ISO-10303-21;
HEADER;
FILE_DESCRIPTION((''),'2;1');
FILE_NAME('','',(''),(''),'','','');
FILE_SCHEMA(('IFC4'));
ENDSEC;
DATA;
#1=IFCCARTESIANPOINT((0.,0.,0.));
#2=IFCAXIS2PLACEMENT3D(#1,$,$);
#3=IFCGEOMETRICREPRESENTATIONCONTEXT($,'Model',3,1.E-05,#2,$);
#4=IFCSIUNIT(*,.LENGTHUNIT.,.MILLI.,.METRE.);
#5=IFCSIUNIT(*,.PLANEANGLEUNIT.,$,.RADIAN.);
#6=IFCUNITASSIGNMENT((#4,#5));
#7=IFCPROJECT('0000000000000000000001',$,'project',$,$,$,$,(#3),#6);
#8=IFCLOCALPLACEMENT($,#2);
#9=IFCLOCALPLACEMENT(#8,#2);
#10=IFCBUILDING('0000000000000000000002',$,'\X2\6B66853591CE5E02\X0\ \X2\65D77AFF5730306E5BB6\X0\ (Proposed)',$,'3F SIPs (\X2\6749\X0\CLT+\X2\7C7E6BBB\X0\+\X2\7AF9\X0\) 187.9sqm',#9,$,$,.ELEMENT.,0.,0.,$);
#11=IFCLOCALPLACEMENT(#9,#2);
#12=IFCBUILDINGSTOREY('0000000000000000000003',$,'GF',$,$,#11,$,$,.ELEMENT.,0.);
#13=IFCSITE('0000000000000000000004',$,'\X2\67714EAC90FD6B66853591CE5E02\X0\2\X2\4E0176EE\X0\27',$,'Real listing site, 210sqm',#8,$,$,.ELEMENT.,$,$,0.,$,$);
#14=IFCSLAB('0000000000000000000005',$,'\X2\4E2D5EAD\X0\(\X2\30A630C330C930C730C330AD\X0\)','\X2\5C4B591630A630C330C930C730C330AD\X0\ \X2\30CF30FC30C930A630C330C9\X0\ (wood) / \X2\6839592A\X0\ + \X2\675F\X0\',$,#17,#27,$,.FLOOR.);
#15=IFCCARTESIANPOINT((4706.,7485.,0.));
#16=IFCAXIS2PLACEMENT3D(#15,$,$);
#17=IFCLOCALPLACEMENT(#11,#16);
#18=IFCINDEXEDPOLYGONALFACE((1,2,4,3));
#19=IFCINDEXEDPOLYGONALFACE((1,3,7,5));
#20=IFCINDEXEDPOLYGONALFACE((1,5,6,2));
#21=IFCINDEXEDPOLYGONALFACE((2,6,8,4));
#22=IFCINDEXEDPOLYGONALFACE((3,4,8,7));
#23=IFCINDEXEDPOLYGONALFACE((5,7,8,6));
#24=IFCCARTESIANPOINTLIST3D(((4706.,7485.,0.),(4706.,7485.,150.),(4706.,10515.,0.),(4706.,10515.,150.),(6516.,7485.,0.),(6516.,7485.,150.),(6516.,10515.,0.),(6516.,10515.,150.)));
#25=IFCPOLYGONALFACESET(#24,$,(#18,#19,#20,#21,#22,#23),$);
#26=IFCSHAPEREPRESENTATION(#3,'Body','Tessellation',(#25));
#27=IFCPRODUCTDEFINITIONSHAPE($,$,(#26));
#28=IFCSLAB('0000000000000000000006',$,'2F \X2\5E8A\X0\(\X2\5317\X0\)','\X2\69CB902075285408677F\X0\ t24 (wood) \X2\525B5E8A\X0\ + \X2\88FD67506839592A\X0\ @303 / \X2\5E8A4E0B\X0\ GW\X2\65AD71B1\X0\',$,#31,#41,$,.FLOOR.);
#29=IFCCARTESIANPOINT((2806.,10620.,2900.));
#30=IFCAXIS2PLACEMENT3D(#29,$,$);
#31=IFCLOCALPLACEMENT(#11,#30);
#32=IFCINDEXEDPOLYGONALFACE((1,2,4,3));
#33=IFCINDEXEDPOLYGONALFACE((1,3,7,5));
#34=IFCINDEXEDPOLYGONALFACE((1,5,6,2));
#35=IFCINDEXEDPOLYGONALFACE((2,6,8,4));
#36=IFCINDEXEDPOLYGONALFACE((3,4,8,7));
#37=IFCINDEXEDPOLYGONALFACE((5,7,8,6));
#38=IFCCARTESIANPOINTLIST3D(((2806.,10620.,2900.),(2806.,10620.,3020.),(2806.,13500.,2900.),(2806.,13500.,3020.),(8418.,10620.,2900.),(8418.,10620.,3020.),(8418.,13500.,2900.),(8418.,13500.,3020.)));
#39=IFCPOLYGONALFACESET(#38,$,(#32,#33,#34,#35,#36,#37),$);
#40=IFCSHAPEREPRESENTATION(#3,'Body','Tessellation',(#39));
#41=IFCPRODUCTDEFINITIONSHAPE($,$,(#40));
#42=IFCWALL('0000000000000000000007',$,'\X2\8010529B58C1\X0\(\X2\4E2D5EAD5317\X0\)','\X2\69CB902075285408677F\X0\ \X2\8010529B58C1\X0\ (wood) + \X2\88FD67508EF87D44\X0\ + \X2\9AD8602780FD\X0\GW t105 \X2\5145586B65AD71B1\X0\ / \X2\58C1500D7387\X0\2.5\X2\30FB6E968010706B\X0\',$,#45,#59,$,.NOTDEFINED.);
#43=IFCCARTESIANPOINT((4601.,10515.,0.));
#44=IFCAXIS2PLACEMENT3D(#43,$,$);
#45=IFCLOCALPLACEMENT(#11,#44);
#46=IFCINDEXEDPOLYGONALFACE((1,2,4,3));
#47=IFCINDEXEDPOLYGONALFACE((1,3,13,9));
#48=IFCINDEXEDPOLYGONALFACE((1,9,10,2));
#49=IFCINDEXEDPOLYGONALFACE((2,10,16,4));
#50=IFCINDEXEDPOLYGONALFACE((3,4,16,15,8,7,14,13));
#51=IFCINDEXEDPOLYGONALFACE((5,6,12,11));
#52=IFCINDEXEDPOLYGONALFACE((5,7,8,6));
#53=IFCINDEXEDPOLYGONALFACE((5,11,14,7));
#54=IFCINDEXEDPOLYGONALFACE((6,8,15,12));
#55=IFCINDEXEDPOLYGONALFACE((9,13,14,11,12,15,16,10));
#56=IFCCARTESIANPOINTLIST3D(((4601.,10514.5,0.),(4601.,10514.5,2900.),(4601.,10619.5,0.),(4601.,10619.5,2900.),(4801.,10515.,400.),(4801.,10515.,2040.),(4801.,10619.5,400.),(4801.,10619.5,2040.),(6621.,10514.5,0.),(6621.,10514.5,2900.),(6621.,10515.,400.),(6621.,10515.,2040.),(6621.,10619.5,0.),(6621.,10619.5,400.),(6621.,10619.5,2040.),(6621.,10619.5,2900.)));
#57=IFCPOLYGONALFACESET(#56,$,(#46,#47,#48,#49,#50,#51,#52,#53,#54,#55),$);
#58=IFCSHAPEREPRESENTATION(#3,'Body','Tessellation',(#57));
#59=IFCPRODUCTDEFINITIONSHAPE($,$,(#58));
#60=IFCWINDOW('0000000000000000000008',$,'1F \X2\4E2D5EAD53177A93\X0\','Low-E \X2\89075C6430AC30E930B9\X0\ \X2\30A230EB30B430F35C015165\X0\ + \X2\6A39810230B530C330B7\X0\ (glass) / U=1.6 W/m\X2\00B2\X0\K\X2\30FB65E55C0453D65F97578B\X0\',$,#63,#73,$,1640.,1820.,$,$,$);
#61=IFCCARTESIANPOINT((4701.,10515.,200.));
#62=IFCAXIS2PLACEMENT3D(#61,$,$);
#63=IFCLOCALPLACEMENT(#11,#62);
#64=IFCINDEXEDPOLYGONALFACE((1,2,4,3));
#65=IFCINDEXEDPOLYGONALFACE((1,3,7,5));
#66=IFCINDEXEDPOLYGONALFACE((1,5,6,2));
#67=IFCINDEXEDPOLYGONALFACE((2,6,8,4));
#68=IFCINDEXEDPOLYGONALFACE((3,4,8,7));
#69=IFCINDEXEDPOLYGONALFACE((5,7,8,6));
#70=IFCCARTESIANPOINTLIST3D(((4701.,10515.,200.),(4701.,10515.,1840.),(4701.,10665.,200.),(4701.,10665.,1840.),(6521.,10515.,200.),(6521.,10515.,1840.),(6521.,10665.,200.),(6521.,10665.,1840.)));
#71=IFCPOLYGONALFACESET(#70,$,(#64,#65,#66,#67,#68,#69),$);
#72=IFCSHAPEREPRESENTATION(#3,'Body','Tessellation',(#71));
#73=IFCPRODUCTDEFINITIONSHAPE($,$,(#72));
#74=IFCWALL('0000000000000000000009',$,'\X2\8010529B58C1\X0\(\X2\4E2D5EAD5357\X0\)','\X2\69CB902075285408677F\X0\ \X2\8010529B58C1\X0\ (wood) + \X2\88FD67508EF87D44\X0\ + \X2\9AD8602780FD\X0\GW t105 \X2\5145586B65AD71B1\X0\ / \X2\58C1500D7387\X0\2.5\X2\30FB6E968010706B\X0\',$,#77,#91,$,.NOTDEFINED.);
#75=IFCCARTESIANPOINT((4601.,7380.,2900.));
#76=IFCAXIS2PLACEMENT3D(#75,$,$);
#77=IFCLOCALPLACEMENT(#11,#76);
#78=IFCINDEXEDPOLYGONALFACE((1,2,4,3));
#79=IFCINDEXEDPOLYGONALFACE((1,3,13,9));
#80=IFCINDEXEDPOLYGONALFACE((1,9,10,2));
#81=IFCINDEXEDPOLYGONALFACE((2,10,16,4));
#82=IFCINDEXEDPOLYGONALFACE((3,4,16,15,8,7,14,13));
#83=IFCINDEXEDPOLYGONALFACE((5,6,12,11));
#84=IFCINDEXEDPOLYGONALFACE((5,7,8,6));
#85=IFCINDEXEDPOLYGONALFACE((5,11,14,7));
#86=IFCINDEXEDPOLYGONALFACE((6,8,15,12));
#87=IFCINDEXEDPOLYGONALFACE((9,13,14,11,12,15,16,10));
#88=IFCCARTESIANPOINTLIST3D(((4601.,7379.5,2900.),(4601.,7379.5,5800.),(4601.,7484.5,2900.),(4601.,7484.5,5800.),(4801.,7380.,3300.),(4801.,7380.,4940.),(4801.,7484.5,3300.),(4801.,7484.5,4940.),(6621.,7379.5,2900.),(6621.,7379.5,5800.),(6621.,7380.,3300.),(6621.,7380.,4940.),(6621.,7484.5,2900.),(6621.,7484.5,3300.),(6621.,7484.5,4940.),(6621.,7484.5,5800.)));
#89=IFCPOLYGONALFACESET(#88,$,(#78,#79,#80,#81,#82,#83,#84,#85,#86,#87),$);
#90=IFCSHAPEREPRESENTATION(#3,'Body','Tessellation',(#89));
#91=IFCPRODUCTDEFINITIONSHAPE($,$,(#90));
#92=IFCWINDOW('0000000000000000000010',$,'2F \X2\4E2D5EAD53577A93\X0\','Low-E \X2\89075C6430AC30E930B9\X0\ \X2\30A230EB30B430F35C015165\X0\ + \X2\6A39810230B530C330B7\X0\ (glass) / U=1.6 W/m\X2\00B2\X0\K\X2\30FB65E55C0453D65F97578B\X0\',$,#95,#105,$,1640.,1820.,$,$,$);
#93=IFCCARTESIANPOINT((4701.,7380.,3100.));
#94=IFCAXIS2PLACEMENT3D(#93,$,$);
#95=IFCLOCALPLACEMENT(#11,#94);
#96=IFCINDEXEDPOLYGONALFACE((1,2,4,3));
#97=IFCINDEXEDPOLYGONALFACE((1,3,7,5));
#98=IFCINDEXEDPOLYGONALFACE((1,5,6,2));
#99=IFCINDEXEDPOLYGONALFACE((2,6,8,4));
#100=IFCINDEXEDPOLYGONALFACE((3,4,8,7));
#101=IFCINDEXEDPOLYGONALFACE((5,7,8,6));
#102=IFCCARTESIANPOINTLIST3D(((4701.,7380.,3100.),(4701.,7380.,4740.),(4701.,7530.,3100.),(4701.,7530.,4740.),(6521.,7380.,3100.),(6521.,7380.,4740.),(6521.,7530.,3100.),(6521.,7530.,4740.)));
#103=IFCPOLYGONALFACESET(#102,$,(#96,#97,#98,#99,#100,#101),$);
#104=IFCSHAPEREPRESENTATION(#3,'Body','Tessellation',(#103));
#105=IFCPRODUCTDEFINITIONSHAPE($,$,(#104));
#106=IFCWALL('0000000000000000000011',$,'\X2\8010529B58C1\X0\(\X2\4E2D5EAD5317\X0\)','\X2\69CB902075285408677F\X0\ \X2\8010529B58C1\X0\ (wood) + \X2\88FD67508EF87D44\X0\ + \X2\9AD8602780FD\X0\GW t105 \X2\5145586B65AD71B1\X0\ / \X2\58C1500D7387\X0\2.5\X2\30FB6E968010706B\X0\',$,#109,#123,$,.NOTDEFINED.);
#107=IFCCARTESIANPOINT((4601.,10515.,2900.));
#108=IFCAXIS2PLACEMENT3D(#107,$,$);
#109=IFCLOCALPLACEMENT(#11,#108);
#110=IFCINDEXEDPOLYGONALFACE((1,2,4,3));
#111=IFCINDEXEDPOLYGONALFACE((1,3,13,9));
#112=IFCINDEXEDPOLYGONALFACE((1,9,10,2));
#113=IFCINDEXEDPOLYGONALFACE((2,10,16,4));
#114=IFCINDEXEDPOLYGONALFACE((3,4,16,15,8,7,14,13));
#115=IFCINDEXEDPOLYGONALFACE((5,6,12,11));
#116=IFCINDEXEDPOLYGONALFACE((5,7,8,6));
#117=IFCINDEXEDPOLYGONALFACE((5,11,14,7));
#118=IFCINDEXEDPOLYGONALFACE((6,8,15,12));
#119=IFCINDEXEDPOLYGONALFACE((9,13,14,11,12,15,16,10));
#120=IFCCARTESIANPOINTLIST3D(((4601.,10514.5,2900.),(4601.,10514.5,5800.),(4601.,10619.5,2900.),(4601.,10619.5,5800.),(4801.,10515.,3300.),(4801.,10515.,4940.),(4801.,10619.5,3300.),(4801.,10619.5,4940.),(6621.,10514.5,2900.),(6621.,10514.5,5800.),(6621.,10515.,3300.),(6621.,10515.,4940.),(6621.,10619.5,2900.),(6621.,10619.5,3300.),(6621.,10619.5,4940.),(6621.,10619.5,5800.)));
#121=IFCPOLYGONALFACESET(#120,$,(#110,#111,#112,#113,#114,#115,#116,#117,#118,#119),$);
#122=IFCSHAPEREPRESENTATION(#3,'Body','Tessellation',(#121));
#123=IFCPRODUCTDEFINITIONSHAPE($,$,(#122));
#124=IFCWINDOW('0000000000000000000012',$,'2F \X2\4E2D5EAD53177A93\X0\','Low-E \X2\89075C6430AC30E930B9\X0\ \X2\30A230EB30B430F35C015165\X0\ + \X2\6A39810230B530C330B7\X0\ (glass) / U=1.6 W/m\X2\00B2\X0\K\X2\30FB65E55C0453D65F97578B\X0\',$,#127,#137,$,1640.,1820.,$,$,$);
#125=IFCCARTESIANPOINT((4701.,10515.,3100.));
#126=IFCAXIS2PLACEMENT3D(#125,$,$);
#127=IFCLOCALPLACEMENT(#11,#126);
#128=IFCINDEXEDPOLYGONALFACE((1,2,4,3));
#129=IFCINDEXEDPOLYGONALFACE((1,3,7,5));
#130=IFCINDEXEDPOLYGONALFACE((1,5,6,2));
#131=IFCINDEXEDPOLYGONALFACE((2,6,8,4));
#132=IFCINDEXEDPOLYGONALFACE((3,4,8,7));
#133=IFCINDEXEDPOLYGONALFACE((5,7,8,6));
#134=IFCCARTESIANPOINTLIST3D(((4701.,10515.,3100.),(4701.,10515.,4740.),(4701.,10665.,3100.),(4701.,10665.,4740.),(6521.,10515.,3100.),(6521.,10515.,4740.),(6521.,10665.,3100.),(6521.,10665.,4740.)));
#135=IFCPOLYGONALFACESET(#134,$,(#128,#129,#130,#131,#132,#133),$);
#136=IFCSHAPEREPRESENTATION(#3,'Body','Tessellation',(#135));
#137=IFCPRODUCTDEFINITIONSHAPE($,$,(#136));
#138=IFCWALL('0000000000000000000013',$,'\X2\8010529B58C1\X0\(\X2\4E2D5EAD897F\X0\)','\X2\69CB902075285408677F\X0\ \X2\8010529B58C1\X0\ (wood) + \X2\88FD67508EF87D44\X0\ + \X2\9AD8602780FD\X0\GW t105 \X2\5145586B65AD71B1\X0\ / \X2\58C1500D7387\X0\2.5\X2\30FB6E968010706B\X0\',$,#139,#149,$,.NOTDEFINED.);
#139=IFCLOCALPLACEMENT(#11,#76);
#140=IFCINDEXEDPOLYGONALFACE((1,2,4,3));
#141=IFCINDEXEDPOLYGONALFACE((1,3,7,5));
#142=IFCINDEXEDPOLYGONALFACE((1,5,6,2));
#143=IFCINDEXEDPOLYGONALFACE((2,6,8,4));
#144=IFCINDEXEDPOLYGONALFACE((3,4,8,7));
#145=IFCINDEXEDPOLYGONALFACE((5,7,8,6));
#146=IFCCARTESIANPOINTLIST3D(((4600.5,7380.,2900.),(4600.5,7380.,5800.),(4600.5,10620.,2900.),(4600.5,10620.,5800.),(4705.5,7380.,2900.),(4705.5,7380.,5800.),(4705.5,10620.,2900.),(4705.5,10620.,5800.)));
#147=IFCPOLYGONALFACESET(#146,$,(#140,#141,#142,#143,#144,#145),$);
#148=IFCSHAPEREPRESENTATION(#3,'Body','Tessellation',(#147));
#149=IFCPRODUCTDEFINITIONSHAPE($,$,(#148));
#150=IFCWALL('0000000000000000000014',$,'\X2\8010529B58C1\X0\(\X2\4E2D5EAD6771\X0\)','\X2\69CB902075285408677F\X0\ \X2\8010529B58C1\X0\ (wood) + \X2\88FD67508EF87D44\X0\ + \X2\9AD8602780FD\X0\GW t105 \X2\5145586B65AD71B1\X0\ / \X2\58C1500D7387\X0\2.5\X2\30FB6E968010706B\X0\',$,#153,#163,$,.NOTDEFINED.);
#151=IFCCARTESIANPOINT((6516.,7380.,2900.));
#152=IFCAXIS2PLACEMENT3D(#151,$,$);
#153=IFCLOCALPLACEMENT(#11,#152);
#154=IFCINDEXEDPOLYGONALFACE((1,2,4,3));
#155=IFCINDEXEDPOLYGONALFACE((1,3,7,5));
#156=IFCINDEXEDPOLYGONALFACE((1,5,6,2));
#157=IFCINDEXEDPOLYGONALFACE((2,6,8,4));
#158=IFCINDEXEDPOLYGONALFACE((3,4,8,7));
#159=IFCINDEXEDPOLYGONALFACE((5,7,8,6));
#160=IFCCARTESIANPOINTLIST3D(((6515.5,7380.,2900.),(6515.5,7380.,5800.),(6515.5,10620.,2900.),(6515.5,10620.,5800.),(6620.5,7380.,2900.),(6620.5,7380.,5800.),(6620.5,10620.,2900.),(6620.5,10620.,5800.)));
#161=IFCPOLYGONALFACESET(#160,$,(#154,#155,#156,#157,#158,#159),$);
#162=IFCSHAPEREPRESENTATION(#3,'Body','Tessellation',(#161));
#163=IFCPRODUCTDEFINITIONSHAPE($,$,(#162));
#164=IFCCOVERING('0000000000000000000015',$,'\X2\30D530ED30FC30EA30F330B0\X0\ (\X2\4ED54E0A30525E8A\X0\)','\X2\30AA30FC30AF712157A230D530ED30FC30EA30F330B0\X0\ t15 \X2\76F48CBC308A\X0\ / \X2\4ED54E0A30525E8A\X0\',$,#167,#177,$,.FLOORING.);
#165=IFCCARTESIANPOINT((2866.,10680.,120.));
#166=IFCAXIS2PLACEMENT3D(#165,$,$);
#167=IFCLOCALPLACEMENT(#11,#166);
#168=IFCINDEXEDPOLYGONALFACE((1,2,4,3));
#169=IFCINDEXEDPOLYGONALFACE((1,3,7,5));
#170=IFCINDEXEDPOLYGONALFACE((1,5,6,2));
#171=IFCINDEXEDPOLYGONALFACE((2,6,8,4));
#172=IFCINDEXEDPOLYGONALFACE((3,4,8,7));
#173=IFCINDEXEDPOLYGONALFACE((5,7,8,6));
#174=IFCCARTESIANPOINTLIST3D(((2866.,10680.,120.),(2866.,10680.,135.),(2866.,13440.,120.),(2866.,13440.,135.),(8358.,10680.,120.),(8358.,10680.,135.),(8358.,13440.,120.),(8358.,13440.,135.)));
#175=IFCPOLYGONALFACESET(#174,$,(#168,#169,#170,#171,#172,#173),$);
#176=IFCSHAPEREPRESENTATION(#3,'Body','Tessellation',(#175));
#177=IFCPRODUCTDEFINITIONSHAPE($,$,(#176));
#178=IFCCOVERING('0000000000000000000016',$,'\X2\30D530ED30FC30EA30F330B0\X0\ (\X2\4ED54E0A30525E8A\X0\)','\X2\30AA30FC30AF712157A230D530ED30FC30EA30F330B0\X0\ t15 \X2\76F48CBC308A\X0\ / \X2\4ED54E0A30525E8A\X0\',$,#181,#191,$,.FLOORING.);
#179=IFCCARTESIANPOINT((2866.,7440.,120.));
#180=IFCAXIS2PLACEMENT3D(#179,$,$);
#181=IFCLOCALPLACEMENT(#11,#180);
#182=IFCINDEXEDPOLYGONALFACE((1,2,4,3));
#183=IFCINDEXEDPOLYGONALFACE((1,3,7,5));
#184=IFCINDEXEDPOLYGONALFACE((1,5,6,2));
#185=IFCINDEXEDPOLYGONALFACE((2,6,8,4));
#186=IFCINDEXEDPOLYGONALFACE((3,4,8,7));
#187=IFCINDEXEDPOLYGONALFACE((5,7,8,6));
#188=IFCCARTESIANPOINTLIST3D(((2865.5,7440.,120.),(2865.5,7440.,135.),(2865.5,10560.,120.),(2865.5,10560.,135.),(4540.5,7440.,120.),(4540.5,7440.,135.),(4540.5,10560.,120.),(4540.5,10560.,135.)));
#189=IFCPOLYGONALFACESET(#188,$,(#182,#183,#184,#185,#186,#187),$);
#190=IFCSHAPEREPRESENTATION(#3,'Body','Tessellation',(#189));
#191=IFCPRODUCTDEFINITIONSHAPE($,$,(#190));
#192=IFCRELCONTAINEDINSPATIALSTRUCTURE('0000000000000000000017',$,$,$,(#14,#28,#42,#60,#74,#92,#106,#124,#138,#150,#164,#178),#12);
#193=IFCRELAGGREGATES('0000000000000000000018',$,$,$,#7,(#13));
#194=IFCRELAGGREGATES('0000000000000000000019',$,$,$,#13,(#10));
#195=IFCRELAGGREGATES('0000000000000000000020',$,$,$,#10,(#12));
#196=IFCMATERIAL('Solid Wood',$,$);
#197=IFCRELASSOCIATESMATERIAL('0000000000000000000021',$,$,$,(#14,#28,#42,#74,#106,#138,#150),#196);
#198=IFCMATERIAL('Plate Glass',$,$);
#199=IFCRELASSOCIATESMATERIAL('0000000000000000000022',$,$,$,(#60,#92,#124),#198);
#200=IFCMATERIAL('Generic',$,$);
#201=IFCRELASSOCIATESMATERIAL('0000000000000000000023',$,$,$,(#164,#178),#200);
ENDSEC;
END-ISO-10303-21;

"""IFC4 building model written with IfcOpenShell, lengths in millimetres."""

from ifc_helpers import new_model, si_unit, frame, frame_2d, origin, place, context, project, spatial, rectangle, extrude, material, element, fill, save


model = new_model("IFC4")

# Units and contexts
model_context = context("Model", 3, precision=1e-05, world=origin())
ifc_project = project(units=[si_unit("LENGTHUNIT", "METRE", prefix="MILLI"), si_unit("PLANEANGLEUNIT", "RADIAN")], contexts=[model_context])

# Site, building, storey
site_placement = place(None, origin())
site = spatial("IfcSite", under=ifc_project, at=site_placement, Name="東京都武蔵野市2丁目27", ObjectType="Real listing site, 210sqm", CompositionType="ELEMENT", RefElevation=0.0)
building_placement = place(site_placement, origin())
building = spatial("IfcBuilding", under=site, at=building_placement, Name="武蔵野市 旗竿地の家 (Proposed)", ObjectType="3F SIPs (杉CLT+籾殻+竹) 187.9sqm", CompositionType="ELEMENT", ElevationOfRefHeight=0.0, ElevationOfTerrain=0.0)
storey_placement = place(building_placement, origin())
storey = spatial("IfcBuildingStorey", under=building, at=storey_placement, Name="GF", CompositionType="ELEMENT", Elevation=0.0)

# Slabs
ifc_material_1 = material(Name="Solid Wood")
slab_1_placement = place(storey_placement, frame((4706.0, 7485.0, 0.0)))
element("IfcSlab", 1, at=slab_1_placement, inside=storey, material=ifc_material_1, Name="中庭(ウッドデッキ)", Description="屋外ウッドデッキ ハードウッド (wood) / 根太 + 束", PredefinedType="FLOOR", context=model_context, shape_type="SweptSolid", body=[
    extrude(rectangle(XDim=1810.0, YDim=3030.0, at=frame_2d((905.0, 1515.0))), frame((4706.0, 7485.0, 0.0)), (0.0, 0.0, 1.0), 150.0),
])
slab_2_placement = place(storey_placement, frame((2806.0, 10620.0, 2900.0)))
element("IfcSlab", 2, at=slab_2_placement, inside=storey, material=ifc_material_1, Name="2F 床(北)", Description="構造用合板 t24 (wood) 剛床 + 製材根太 @303 / 床下 GW断熱", PredefinedType="FLOOR", context=model_context, shape_type="SweptSolid", body=[
    extrude(rectangle(XDim=5612.0, YDim=2880.0, at=frame_2d((2806.0, 1440.0))), frame((2806.0, 10620.0, 2900.0)), (0.0, 0.0, 1.0), 120.0),
])

# Wall, opening, window
wall_1_placement = place(storey_placement, frame((4601.0, 10515.0, 0.0)))
wall_1 = element("IfcWall", 3, at=wall_1_placement, inside=storey, material=ifc_material_1, Name="耐力壁(中庭北)", Description="構造用合板 耐力壁 (wood) + 製材軸組 + 高性能GW t105 充填断熱 / 壁倍率2.5・準耐火", PredefinedType="NOTDEFINED", context=model_context, shape_type="SweptSolid", body=[
    extrude(rectangle(XDim=2020.0, YDim=105.0, at=frame_2d((1010.0, 52.0))), frame((4601.0, 10515.0, 0.0)), (0.0, 0.0, 1.0), 2900.0),
])
opening_1_placement = place(storey_placement, frame((4701.0, 10515.0, 200.0)))
opening_1 = element("IfcOpeningElement", 4, at=opening_1_placement, cuts=wall_1, PredefinedType="NOTDEFINED", context=model_context, shape_type="SweptSolid", body=[
    extrude(rectangle(XDim=1820.0, YDim=150.0, at=frame_2d((910.0, 75.0))), frame((4701.0, 10515.0, 200.0)), (0.0, 0.0, 1.0), 1640.0),
])
ifc_material_2 = material(Name="Plate Glass")
window_1_placement = place(storey_placement, frame((4701.0, 10515.0, 200.0)))
window_1 = element("IfcWindow", 5, at=window_1_placement, inside=storey, material=ifc_material_2, Name="1F 中庭北窓", Description="Low-E 複層ガラス アルゴン封入 + 樹脂サッシ (glass) / U=1.6 W/m²K・日射取得型", OverallHeight=1640.0, OverallWidth=1820.0, context=model_context, shape_type="SweptSolid", body=[
    extrude(rectangle(XDim=1820.0, YDim=150.0, at=frame_2d((910.0, 75.0))), frame((4701.0, 10515.0, 200.0)), (0.0, 0.0, 1.0), 1640.0),
])
fill(opening_1, window_1)

# Walls, openings, windows
wall_2_placement = place(storey_placement, frame((4601.0, 7380.0, 2900.0)))
wall_2 = element("IfcWall", 6, at=wall_2_placement, inside=storey, material=ifc_material_1, Name="耐力壁(中庭南)", Description="構造用合板 耐力壁 (wood) + 製材軸組 + 高性能GW t105 充填断熱 / 壁倍率2.5・準耐火", PredefinedType="NOTDEFINED", context=model_context, shape_type="SweptSolid", body=[
    extrude(rectangle(XDim=2020.0, YDim=105.0, at=frame_2d((1010.0, 52.0))), frame((4601.0, 7380.0, 2900.0)), (0.0, 0.0, 1.0), 2900.0),
])
opening_2_placement = place(storey_placement, frame((4701.0, 7380.0, 3100.0)))
opening_2 = element("IfcOpeningElement", 7, at=opening_2_placement, cuts=wall_2, PredefinedType="NOTDEFINED", context=model_context, shape_type="SweptSolid", body=[
    extrude(rectangle(XDim=1820.0, YDim=150.0, at=frame_2d((910.0, 75.0))), frame((4701.0, 7380.0, 3100.0)), (0.0, 0.0, 1.0), 1640.0),
])
window_2_placement = place(storey_placement, frame((4701.0, 7380.0, 3100.0)))
window_2 = element("IfcWindow", 8, at=window_2_placement, inside=storey, material=ifc_material_2, Name="2F 中庭南窓", Description="Low-E 複層ガラス アルゴン封入 + 樹脂サッシ (glass) / U=1.6 W/m²K・日射取得型", OverallHeight=1640.0, OverallWidth=1820.0, context=model_context, shape_type="SweptSolid", body=[
    extrude(rectangle(XDim=1820.0, YDim=150.0, at=frame_2d((910.0, 75.0))), frame((4701.0, 7380.0, 3100.0)), (0.0, 0.0, 1.0), 1640.0),
])
fill(opening_2, window_2)
wall_3_placement = place(storey_placement, frame((4601.0, 10515.0, 2900.0)))
wall_3 = element("IfcWall", 9, at=wall_3_placement, inside=storey, material=ifc_material_1, Name="耐力壁(中庭北)", Description="構造用合板 耐力壁 (wood) + 製材軸組 + 高性能GW t105 充填断熱 / 壁倍率2.5・準耐火", PredefinedType="NOTDEFINED", context=model_context, shape_type="SweptSolid", body=[
    extrude(rectangle(XDim=2020.0, YDim=105.0, at=frame_2d((1010.0, 52.0))), frame((4601.0, 10515.0, 2900.0)), (0.0, 0.0, 1.0), 2900.0),
])
opening_3_placement = place(storey_placement, frame((4701.0, 10515.0, 3100.0)))
opening_3 = element("IfcOpeningElement", 10, at=opening_3_placement, cuts=wall_3, PredefinedType="NOTDEFINED", context=model_context, shape_type="SweptSolid", body=[
    extrude(rectangle(XDim=1820.0, YDim=150.0, at=frame_2d((910.0, 75.0))), frame((4701.0, 10515.0, 3100.0)), (0.0, 0.0, 1.0), 1640.0),
])
window_3_placement = place(storey_placement, frame((4701.0, 10515.0, 3100.0)))
window_3 = element("IfcWindow", 11, at=window_3_placement, inside=storey, material=ifc_material_2, Name="2F 中庭北窓", Description="Low-E 複層ガラス アルゴン封入 + 樹脂サッシ (glass) / U=1.6 W/m²K・日射取得型", OverallHeight=1640.0, OverallWidth=1820.0, context=model_context, shape_type="SweptSolid", body=[
    extrude(rectangle(XDim=1820.0, YDim=150.0, at=frame_2d((910.0, 75.0))), frame((4701.0, 10515.0, 3100.0)), (0.0, 0.0, 1.0), 1640.0),
])
fill(opening_3, window_3)

# Walls
wall_4_placement = place(storey_placement, frame((4601.0, 7380.0, 2900.0)))
element("IfcWall", 12, at=wall_4_placement, inside=storey, material=ifc_material_1, Name="耐力壁(中庭西)", Description="構造用合板 耐力壁 (wood) + 製材軸組 + 高性能GW t105 充填断熱 / 壁倍率2.5・準耐火", PredefinedType="NOTDEFINED", context=model_context, shape_type="SweptSolid", body=[
    extrude(rectangle(XDim=105.0, YDim=3240.0, at=frame_2d((52.0, 1620.0))), frame((4601.0, 7380.0, 2900.0)), (0.0, 0.0, 1.0), 2900.0),
])
wall_5_placement = place(storey_placement, frame((6516.0, 7380.0, 2900.0)))
element("IfcWall", 13, at=wall_5_placement, inside=storey, material=ifc_material_1, Name="耐力壁(中庭東)", Description="構造用合板 耐力壁 (wood) + 製材軸組 + 高性能GW t105 充填断熱 / 壁倍率2.5・準耐火", PredefinedType="NOTDEFINED", context=model_context, shape_type="SweptSolid", body=[
    extrude(rectangle(XDim=105.0, YDim=3240.0, at=frame_2d((52.0, 1620.0))), frame((6516.0, 7380.0, 2900.0)), (0.0, 0.0, 1.0), 2900.0),
])

# Coverings
ifc_material_3 = material(Name="Generic")
covering_1_placement = place(storey_placement, frame((2866.0, 10680.0, 120.0)))
element("IfcCovering", 14, at=covering_1_placement, inside=storey, material=ifc_material_3, Name="フローリング (仕上げ床)", Description="オーク無垢フローリング t15 直貼り / 仕上げ床", PredefinedType="FLOORING", context=model_context, shape_type="SweptSolid", body=[
    extrude(rectangle(XDim=5492.0, YDim=2760.0, at=frame_2d((2746.0, 1380.0))), frame((2866.0, 10680.0, 120.0)), (0.0, 0.0, 1.0), 15.0),
])
covering_2_placement = place(storey_placement, frame((2866.0, 7440.0, 120.0)))
element("IfcCovering", 15, at=covering_2_placement, inside=storey, material=ifc_material_3, Name="フローリング (仕上げ床)", Description="オーク無垢フローリング t15 直貼り / 仕上げ床", PredefinedType="FLOORING", context=model_context, shape_type="SweptSolid", body=[
    extrude(rectangle(XDim=1675.0, YDim=3120.0, at=frame_2d((837.0, 1560.0))), frame((2866.0, 7440.0, 120.0)), (0.0, 0.0, 1.0), 15.0),
])

save(model, "model.ifc")
